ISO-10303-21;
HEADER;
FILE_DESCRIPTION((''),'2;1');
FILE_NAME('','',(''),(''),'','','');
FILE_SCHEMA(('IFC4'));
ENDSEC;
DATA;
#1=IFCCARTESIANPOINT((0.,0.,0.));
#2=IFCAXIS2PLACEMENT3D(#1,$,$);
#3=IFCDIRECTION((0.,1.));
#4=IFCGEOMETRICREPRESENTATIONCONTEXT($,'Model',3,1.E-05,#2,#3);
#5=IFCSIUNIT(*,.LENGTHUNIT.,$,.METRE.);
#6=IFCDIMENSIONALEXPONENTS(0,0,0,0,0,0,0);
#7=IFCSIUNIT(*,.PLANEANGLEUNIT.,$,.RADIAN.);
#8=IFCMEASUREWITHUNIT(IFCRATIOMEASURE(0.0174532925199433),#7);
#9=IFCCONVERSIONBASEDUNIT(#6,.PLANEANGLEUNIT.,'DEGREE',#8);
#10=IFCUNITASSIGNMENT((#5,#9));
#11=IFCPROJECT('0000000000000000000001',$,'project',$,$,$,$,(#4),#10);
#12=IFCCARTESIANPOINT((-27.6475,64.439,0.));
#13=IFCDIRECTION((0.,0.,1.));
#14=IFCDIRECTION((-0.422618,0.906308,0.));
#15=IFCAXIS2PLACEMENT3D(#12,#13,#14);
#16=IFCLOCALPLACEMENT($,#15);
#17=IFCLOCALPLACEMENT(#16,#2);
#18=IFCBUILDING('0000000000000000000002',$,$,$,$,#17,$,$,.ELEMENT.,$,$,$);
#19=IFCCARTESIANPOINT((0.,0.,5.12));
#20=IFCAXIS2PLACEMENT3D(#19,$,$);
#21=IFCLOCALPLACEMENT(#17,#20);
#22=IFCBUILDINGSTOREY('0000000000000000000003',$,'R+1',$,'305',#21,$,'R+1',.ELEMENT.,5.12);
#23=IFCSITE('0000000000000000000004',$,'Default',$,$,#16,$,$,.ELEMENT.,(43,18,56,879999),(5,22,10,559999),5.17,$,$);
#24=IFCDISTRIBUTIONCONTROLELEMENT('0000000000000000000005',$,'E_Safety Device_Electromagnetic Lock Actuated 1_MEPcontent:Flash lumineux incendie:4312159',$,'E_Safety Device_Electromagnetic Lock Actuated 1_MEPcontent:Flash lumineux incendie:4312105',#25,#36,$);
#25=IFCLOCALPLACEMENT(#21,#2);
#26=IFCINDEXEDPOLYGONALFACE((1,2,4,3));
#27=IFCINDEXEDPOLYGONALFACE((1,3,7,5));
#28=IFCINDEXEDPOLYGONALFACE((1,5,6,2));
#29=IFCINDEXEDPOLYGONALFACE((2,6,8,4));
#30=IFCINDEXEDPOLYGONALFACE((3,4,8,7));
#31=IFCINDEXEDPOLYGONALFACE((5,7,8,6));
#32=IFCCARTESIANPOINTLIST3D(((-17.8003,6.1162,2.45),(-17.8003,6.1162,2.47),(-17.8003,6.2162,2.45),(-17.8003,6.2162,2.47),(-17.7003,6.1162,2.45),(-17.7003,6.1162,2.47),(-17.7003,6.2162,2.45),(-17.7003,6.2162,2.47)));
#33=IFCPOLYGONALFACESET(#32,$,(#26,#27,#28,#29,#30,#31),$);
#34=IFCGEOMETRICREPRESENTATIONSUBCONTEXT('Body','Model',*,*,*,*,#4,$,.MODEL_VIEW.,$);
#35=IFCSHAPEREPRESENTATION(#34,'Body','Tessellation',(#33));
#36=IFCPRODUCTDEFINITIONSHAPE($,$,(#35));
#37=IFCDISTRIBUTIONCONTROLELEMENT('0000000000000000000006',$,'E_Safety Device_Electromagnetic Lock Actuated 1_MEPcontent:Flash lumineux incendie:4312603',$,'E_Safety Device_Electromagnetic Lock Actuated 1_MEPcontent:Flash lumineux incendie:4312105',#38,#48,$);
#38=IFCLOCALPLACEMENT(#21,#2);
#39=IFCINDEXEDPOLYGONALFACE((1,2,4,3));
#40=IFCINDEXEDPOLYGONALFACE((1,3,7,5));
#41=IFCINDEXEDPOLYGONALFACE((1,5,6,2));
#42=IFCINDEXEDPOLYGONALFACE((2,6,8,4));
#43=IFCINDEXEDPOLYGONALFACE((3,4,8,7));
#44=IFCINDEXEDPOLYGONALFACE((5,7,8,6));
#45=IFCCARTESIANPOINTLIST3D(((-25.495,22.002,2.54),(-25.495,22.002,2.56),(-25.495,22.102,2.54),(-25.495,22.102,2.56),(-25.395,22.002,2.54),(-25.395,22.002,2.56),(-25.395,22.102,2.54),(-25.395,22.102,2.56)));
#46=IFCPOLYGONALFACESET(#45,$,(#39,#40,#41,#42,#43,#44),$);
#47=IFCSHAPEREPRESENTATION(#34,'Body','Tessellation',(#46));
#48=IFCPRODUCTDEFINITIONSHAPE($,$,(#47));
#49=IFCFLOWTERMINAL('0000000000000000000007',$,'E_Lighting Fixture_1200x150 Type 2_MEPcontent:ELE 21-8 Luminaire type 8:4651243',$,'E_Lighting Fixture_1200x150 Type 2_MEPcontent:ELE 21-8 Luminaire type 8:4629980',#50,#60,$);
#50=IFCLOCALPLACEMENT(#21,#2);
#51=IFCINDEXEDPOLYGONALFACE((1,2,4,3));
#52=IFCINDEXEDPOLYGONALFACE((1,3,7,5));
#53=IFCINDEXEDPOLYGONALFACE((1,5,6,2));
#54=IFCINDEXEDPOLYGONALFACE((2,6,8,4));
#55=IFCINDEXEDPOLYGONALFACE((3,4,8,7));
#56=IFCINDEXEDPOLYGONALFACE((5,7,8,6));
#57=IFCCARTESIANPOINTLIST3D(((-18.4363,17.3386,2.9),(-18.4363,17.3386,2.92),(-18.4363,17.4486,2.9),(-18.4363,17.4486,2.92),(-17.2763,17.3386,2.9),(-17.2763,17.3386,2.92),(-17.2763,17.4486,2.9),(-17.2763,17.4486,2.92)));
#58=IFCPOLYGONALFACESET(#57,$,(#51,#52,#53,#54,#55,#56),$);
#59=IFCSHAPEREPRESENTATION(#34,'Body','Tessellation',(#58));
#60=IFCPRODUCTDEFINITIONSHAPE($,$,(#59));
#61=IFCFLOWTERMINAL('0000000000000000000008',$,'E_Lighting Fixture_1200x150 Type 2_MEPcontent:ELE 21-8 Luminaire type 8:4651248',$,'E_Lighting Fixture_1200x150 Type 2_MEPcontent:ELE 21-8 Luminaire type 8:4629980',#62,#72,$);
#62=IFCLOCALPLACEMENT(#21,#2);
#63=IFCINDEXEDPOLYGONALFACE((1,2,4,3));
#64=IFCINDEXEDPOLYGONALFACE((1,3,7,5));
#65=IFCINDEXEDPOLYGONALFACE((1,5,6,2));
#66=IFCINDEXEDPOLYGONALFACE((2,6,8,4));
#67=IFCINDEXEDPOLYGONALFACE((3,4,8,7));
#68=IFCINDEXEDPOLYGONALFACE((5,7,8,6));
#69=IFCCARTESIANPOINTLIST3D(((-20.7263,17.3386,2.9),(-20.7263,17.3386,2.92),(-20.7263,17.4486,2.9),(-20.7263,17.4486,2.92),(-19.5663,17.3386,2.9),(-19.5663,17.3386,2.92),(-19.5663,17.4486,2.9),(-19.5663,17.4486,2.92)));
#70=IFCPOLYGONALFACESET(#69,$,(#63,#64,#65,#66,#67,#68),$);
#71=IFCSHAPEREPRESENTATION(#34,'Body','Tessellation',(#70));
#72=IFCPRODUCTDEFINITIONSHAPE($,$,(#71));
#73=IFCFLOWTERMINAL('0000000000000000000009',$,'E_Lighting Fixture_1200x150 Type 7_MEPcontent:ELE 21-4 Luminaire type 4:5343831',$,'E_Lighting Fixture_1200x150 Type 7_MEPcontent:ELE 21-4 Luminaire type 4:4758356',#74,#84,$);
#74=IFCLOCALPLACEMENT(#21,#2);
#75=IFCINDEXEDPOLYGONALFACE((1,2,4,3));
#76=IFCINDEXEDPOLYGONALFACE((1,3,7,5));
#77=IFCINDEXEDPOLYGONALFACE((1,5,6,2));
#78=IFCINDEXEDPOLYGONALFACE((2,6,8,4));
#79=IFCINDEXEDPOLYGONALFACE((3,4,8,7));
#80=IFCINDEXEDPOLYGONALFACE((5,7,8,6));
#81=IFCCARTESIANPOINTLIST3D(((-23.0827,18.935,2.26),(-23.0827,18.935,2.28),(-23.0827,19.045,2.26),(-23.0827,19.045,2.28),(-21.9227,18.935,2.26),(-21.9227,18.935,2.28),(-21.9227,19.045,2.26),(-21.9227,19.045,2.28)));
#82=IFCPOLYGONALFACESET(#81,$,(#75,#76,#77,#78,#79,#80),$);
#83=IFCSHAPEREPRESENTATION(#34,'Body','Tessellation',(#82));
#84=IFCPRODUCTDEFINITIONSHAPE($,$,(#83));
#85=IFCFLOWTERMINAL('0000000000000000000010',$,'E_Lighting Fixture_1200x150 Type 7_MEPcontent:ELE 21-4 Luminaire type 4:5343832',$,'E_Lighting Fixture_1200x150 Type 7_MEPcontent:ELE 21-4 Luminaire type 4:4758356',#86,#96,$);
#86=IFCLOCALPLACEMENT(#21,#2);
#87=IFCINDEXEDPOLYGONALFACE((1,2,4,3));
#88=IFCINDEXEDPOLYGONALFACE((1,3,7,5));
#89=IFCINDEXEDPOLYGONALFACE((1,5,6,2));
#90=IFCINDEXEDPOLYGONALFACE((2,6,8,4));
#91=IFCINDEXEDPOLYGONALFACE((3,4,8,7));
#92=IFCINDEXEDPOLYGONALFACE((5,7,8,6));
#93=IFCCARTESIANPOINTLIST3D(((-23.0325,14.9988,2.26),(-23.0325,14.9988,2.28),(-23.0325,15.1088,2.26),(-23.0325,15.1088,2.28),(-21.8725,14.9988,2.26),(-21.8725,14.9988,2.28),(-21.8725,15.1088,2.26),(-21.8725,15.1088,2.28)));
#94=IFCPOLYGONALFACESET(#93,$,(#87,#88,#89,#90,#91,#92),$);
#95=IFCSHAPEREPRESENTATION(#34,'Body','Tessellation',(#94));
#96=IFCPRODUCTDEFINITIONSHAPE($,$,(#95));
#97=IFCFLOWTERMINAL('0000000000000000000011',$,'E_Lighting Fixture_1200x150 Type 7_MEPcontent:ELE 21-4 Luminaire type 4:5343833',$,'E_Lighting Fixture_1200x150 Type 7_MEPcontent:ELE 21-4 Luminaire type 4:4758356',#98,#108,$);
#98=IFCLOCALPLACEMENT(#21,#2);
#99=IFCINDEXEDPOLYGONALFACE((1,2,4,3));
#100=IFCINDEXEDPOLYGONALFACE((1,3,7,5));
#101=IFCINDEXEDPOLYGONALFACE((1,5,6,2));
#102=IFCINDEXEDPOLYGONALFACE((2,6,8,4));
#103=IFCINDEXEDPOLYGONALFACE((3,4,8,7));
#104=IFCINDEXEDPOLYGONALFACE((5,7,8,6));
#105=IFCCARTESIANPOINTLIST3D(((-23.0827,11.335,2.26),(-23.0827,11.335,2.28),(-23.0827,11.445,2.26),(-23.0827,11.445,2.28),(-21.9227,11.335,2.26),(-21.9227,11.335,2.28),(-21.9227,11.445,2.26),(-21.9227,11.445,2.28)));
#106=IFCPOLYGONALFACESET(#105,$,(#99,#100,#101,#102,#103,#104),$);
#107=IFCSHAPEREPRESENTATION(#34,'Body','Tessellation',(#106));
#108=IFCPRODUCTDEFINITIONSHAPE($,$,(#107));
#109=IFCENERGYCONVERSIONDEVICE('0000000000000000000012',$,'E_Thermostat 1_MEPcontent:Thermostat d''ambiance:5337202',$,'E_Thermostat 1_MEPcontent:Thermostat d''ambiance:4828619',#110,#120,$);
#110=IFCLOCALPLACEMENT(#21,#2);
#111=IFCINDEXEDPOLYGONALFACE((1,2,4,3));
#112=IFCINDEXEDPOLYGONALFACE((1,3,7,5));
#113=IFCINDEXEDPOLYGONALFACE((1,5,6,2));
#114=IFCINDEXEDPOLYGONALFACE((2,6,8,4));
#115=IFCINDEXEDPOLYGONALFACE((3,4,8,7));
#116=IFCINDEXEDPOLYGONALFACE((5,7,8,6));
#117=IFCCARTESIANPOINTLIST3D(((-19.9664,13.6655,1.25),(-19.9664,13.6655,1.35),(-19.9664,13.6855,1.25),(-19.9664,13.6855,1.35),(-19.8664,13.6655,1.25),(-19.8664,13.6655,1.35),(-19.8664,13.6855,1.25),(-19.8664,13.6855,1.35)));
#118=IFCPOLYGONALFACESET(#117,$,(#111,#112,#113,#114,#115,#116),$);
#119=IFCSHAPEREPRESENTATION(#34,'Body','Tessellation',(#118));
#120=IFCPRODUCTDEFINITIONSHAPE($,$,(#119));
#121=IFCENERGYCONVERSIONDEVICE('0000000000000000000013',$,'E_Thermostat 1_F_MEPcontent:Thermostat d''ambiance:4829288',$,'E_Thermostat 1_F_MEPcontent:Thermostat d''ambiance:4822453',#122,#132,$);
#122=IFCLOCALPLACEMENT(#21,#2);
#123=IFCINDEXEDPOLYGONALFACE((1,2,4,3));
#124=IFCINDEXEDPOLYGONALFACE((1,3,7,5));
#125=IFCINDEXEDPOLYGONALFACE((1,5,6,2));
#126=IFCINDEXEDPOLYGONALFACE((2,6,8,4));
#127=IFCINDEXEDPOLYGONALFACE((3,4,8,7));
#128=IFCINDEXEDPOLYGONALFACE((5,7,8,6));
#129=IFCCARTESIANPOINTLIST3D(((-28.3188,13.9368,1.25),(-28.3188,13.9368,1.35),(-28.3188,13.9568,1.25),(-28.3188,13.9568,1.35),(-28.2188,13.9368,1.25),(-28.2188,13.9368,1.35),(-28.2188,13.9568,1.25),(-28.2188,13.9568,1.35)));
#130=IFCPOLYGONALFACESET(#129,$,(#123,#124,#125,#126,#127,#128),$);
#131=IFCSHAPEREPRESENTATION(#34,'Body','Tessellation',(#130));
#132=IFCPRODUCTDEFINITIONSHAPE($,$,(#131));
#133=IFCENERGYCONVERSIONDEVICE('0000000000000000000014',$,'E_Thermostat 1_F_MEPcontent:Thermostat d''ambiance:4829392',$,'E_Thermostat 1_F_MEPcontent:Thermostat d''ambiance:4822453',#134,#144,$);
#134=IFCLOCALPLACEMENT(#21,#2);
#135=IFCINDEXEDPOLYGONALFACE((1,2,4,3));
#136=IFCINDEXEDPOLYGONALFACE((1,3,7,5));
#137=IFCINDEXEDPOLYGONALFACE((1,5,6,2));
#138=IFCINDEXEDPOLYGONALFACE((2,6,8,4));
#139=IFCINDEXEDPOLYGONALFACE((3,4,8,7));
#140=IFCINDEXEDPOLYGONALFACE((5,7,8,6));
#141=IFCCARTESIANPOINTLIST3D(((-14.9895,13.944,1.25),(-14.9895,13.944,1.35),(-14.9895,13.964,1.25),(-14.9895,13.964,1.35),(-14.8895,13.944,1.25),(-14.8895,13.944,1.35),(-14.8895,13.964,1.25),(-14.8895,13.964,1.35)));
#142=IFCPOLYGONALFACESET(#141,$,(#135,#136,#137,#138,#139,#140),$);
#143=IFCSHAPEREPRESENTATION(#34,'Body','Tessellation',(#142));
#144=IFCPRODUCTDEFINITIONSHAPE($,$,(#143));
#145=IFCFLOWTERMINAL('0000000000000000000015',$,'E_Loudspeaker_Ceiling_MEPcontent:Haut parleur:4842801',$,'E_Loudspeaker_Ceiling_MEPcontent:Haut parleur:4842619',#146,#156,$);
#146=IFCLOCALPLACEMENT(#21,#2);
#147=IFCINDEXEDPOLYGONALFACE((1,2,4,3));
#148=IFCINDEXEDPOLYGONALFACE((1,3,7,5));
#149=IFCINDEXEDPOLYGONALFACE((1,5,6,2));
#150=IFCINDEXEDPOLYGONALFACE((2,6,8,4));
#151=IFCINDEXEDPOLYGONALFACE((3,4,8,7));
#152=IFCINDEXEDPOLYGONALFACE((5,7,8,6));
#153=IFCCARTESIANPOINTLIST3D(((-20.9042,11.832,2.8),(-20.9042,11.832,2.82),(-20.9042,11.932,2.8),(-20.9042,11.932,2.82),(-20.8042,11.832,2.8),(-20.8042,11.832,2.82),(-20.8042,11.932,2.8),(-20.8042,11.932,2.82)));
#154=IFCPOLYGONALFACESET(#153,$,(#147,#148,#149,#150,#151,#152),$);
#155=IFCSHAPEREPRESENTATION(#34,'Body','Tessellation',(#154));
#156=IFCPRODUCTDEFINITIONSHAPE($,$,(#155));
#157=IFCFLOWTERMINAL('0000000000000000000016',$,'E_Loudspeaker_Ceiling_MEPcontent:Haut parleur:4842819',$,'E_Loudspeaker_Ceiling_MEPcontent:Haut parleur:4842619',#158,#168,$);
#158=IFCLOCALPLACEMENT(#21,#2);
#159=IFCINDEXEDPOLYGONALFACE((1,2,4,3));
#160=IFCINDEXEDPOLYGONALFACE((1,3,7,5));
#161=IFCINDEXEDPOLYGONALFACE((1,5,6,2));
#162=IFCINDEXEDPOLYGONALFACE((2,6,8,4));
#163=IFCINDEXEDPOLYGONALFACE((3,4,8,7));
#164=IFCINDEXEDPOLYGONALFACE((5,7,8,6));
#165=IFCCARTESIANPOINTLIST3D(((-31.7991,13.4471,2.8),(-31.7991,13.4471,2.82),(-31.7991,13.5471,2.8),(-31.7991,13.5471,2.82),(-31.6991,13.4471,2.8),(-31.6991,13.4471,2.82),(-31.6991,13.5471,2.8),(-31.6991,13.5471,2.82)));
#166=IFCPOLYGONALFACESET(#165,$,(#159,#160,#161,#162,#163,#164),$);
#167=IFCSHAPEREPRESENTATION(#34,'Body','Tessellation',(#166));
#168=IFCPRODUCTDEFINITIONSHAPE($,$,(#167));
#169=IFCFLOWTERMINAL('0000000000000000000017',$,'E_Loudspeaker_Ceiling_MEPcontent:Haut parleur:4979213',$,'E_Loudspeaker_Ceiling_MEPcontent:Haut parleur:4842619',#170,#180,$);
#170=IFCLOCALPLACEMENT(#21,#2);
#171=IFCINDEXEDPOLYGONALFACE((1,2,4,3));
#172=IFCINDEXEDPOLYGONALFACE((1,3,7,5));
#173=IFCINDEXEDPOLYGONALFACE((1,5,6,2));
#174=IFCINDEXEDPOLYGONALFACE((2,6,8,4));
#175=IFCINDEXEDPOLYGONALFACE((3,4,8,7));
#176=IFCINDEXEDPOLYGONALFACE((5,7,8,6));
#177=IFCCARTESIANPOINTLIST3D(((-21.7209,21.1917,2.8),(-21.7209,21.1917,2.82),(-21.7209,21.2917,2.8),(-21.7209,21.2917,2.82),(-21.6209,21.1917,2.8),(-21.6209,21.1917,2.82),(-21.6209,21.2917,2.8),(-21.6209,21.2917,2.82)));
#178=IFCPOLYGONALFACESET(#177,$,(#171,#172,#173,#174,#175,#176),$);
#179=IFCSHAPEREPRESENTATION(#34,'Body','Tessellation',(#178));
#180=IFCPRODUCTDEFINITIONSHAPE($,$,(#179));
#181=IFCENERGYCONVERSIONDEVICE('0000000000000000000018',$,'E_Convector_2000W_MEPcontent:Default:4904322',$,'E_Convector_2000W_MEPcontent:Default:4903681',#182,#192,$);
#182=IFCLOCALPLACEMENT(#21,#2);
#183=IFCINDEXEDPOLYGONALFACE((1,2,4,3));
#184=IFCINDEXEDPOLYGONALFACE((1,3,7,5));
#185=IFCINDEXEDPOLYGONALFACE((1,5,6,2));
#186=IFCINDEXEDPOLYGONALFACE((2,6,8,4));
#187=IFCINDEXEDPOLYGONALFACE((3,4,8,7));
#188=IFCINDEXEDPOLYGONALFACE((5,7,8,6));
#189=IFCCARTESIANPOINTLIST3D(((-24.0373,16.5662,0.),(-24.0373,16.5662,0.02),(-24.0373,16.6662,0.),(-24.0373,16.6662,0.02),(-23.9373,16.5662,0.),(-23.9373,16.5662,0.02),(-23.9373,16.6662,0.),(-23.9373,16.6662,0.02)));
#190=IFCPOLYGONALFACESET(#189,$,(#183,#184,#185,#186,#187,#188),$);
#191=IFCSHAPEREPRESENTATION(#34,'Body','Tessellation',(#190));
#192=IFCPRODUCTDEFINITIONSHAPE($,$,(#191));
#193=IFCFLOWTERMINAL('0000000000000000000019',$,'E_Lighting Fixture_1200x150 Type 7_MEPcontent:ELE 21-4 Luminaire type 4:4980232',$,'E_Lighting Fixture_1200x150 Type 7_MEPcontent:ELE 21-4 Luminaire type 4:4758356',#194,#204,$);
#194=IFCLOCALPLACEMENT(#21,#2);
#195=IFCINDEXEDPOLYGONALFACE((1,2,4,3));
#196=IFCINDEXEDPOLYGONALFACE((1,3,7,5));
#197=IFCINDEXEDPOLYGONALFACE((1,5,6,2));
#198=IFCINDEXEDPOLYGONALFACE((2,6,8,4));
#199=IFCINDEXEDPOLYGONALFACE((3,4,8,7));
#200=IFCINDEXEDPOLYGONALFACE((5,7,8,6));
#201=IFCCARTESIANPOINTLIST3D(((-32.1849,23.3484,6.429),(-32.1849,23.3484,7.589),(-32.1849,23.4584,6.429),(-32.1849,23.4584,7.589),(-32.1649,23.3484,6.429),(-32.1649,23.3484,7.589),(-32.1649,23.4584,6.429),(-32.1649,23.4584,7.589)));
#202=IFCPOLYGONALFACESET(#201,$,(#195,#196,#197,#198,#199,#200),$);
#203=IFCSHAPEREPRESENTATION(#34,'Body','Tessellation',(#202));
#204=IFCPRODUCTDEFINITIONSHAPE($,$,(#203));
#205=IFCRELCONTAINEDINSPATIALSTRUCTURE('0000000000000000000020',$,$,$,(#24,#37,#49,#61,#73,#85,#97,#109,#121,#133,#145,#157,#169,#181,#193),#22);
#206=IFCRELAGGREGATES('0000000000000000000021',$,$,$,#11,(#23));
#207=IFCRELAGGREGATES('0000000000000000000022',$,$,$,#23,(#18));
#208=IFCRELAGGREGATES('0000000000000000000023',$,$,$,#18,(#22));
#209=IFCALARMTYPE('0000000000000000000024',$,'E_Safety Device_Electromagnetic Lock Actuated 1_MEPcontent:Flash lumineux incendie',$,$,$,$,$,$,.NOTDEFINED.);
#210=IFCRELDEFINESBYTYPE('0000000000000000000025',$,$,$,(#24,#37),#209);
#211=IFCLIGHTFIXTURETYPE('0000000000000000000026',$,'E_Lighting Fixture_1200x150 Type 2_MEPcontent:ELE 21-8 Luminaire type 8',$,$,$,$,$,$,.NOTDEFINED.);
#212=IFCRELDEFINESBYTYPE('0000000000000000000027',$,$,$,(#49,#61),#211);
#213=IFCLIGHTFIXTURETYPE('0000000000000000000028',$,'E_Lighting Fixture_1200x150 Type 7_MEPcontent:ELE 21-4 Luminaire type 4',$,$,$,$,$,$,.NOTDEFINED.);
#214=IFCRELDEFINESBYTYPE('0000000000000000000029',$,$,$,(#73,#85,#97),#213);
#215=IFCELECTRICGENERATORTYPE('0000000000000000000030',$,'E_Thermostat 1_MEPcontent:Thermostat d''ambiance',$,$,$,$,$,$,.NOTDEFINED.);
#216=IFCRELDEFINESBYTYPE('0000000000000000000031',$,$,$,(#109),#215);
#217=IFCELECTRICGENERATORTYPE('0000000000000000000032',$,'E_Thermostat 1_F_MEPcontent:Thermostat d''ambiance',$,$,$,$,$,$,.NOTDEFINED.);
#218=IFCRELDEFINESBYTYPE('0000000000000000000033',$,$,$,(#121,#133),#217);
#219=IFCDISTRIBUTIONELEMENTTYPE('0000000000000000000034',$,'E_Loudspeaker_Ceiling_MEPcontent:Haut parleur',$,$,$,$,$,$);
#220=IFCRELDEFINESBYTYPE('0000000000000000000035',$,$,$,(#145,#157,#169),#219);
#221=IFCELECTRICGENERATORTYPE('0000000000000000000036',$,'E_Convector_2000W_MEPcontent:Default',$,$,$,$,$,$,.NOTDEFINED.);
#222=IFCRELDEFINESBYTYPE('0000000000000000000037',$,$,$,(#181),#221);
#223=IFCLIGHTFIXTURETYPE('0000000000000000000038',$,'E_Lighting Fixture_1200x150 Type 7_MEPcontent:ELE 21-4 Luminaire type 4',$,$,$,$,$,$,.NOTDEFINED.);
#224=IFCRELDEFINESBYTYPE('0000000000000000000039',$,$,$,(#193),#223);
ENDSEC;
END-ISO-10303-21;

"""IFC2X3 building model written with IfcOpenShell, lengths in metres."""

from ifc_helpers import new_model, entity, si_unit, converted_unit, direction, frame, frame_2d, origin, origin_2d_with_axis, place, context, subcontext, project, spatial, rectangle, extrude, source, transform, mapped, type_object, type_shapes, element, save


model = new_model("IFC2X3")

# Units and contexts
model_context = context("Model", 3, precision=1e-05, world=origin(), true_north=direction((0.0, 1.0)))
body_context = subcontext(model_context, "Body", "Model", "MODEL_VIEW")
ifc_project = project(units=[si_unit("LENGTHUNIT", "METRE"), converted_unit("PLANEANGLEUNIT", "DEGREE", entity("IfcRatioMeasure", 0.0174532925199433), si_unit("PLANEANGLEUNIT", "RADIAN"), dimensions=[0, 0, 0, 0, 0, 0, 0])], contexts=[model_context])

# Site, building, storey
site_placement = place(None, frame((-27.6475, 64.439, 0.0), z_axis=(0.0, 0.0, 1.0), x_axis=(-0.422618, 0.906308, 0.0)))
site = spatial("IfcSite", under=ifc_project, at=site_placement, Name="Default", CompositionType="ELEMENT", RefLatitude=(43, 18, 56, 879999), RefLongitude=(5, 22, 10, 559999), RefElevation=5.17)
building_placement = place(site_placement, origin())
building = spatial("IfcBuilding", under=site, at=building_placement, CompositionType="ELEMENT")
storey_placement = place(building_placement, frame((0.0, 0.0, 5.12)))
storey = spatial("IfcBuildingStorey", under=building, at=storey_placement, Name="R+1", ObjectType="305", LongName="R+1", CompositionType="ELEMENT", Elevation=5.12)

# Distribution control elements
alarm_type = type_object("IfcAlarmType", Name="E_Safety Device_Electromagnetic Lock Actuated 1_MEPcontent:Flash lumineux incendie", PredefinedType="NOTDEFINED")
shared_shape_1 = source(origin(), body_context, "Body", "SweptSolid", [
    extrude(rectangle(XDim=0.1, YDim=0.1, at=origin_2d_with_axis()), frame((0.0, 0.0, 0.0), z_axis=(0.0, 0.0, 1.0), x_axis=(0.0, -1.0, 0.0)), (0.0, 0.0, 1.0), 0.02),
])
type_shapes(alarm_type, [shared_shape_1])
for number, where, z_axis, x_axis, name in (
    (1, (-17.7503, 6.1662, 2.45), (0.0, 0.0, 1.0), (0.0, -1.0, 0.0), "E_Safety Device_Electromagnetic Lock Actuated 1_MEPcontent:Flash lumineux incendie:4312159"),
    (2, (-25.445, 22.052, 2.54), (0.0, 0.0, 1.0), (0.0, -1.0, 0.0), "E_Safety Device_Electromagnetic Lock Actuated 1_MEPcontent:Flash lumineux incendie:4312603"),
):
    element("IfcDistributionControlElement", number, at=place(storey_placement, frame(where, z_axis=z_axis, x_axis=x_axis)), inside=storey, type_object=alarm_type, Name=name, ObjectType="E_Safety Device_Electromagnetic Lock Actuated 1_MEPcontent:Flash lumineux incendie:4312105", context=body_context, shape_type="MappedRepresentation", body=[
        mapped(shared_shape_1, transform((0.0, 0.0, 0.0), scale=1.0)),
    ])

# Flow terminals
light_fixture_type_1 = type_object("IfcLightFixtureType", Name="E_Lighting Fixture_1200x150 Type 2_MEPcontent:ELE 21-8 Luminaire type 8", PredefinedType="NOTDEFINED")
shared_shape_2 = source(origin(), body_context, "Body", "SweptSolid", [
    extrude(rectangle(XDim=0.11, YDim=1.16, at=origin_2d_with_axis()), frame((0.0, 0.0, 0.0), z_axis=(0.0, 0.0, 1.0), x_axis=(0.0, -1.0, 0.0)), (0.0, 0.0, 1.0), 0.02),
])
type_shapes(light_fixture_type_1, [shared_shape_2])
for number, where, z_axis, x_axis, name in (
    (3, (-17.8563, 17.3936, 2.9), (0.0, 0.0, 1.0), (-1.0, 0.0, 0.0), "E_Lighting Fixture_1200x150 Type 2_MEPcontent:ELE 21-8 Luminaire type 8:4651243"),
    (4, (-20.1463, 17.3936, 2.9), (0.0, 0.0, 1.0), (-1.0, 0.0, 0.0), "E_Lighting Fixture_1200x150 Type 2_MEPcontent:ELE 21-8 Luminaire type 8:4651248"),
):
    element("IfcFlowTerminal", number, at=place(storey_placement, frame(where, z_axis=z_axis, x_axis=x_axis)), inside=storey, type_object=light_fixture_type_1, Name=name, ObjectType="E_Lighting Fixture_1200x150 Type 2_MEPcontent:ELE 21-8 Luminaire type 8:4629980", context=body_context, shape_type="MappedRepresentation", body=[
        mapped(shared_shape_2, transform((0.0, 0.0, 0.0), scale=1.0)),
    ])
light_fixture_type_2 = type_object("IfcLightFixtureType", Name="E_Lighting Fixture_1200x150 Type 7_MEPcontent:ELE 21-4 Luminaire type 4", PredefinedType="NOTDEFINED")
shared_shape_3 = source(origin(), body_context, "Body", "SweptSolid", [
    extrude(rectangle(XDim=0.11, YDim=1.16, at=origin_2d_with_axis()), frame((0.0, 0.0, 0.0), z_axis=(0.0, 0.0, 1.0), x_axis=(0.0, -1.0, 0.0)), (0.0, 0.0, 1.0), 0.02),
])
type_shapes(light_fixture_type_2, [shared_shape_3])
for number, where, name in (
    (5, (-22.5027, 18.99, 2.26), "E_Lighting Fixture_1200x150 Type 7_MEPcontent:ELE 21-4 Luminaire type 4:5343831"),
    (6, (-22.4525, 15.0538, 2.26), "E_Lighting Fixture_1200x150 Type 7_MEPcontent:ELE 21-4 Luminaire type 4:5343832"),
    (7, (-22.5027, 11.39, 2.26), "E_Lighting Fixture_1200x150 Type 7_MEPcontent:ELE 21-4 Luminaire type 4:5343833"),
):
    element("IfcFlowTerminal", number, at=place(storey_placement, frame(where)), inside=storey, type_object=light_fixture_type_2, Name=name, ObjectType="E_Lighting Fixture_1200x150 Type 7_MEPcontent:ELE 21-4 Luminaire type 4:4758356", context=body_context, shape_type="MappedRepresentation", body=[
        mapped(shared_shape_3, transform((0.0, 0.0, 0.0), scale=1.0)),
    ])

# Energy conversion devices
electric_generator_type_1 = type_object("IfcElectricGeneratorType", Name="E_Thermostat 1_MEPcontent:Thermostat d'ambiance", PredefinedType="NOTDEFINED")
shared_shape_4 = source(origin(), body_context, "Body", "SweptSolid", [
    extrude(rectangle(XDim=0.02, YDim=0.1, at=frame_2d((0.0, 0.0), x_axis=(1.0, 0.0))), frame((0.0, 0.01, -0.05), z_axis=(0.0, 0.0, 1.0), x_axis=(0.0, -1.0, 0.0)), (0.0, 0.0, 1.0), 0.1),
])
type_shapes(electric_generator_type_1, [shared_shape_4])
energy_conversion_device_1_placement = place(storey_placement, frame((-19.9164, 13.6855, 1.3), z_axis=(0.0, 0.0, 1.0), x_axis=(-1.0, 0.0, 0.0)))
element("IfcEnergyConversionDevice", 8, at=energy_conversion_device_1_placement, inside=storey, type_object=electric_generator_type_1, Name="E_Thermostat 1_MEPcontent:Thermostat d'ambiance:5337202", ObjectType="E_Thermostat 1_MEPcontent:Thermostat d'ambiance:4828619", context=body_context, shape_type="MappedRepresentation", body=[
    mapped(shared_shape_4, transform((0.0, 0.0, 0.0), scale=1.0)),
])
electric_generator_type_2 = type_object("IfcElectricGeneratorType", Name="E_Thermostat 1_F_MEPcontent:Thermostat d'ambiance", PredefinedType="NOTDEFINED")
shared_shape_5 = source(origin(), body_context, "Body", "SweptSolid", [
    extrude(rectangle(XDim=0.1, YDim=0.1, at=origin_2d_with_axis()), frame((0.0, 0.0, 0.0), z_axis=(0.0, 0.0, 1.0), x_axis=(0.0, 1.0, 0.0)), (0.0, 0.0, 1.0), 0.02),
])
type_shapes(electric_generator_type_2, [shared_shape_5])
for number, where, z_axis, x_axis, name in (
    (9, (-28.2688, 13.9368, 1.3), (0.0, 1.0, 0.0), (-1.0, 0.0, 0.0), "E_Thermostat 1_F_MEPcontent:Thermostat d'ambiance:4829288"),
    (10, (-14.9395, 13.944, 1.3), (0.0, 1.0, 0.0), (-1.0, 0.0, 0.0), "E_Thermostat 1_F_MEPcontent:Thermostat d'ambiance:4829392"),
):
    element("IfcEnergyConversionDevice", number, at=place(storey_placement, frame(where, z_axis=z_axis, x_axis=x_axis)), inside=storey, type_object=electric_generator_type_2, Name=name, ObjectType="E_Thermostat 1_F_MEPcontent:Thermostat d'ambiance:4822453", context=body_context, shape_type="MappedRepresentation", body=[
        mapped(shared_shape_5, transform((0.0, 0.0, 0.0), scale=1.0)),
    ])

# Flow terminals
distribution_element_type = type_object("IfcDistributionElementType", Name="E_Loudspeaker_Ceiling_MEPcontent:Haut parleur")
shared_shape_6 = source(origin(), body_context, "Body", "SweptSolid", [
    extrude(rectangle(XDim=0.1, YDim=0.1, at=origin_2d_with_axis()), frame((0.0, 0.0, 0.0), z_axis=(0.0, 0.0, 1.0), x_axis=(0.0, -1.0, 0.0)), (0.0, 0.0, 1.0), 0.02),
])
type_shapes(distribution_element_type, [shared_shape_6])
for number, where, z_axis, x_axis, name in (
    (11, (-20.8542, 11.882, 2.8), (0.0, 0.0, 1.0), (0.0, -1.0, 0.0), "E_Loudspeaker_Ceiling_MEPcontent:Haut parleur:4842801"),
    (12, (-31.7491, 13.4971, 2.8), (0.0, 0.0, 1.0), (-1.0, 0.0, 0.0), "E_Loudspeaker_Ceiling_MEPcontent:Haut parleur:4842819"),
    (13, (-21.6709, 21.2417, 2.8), (0.0, 0.0, 1.0), (0.0, 1.0, 0.0), "E_Loudspeaker_Ceiling_MEPcontent:Haut parleur:4979213"),
):
    element("IfcFlowTerminal", number, at=place(storey_placement, frame(where, z_axis=z_axis, x_axis=x_axis)), inside=storey, type_object=distribution_element_type, Name=name, ObjectType="E_Loudspeaker_Ceiling_MEPcontent:Haut parleur:4842619", context=body_context, shape_type="MappedRepresentation", body=[
        mapped(shared_shape_6, transform((0.0, 0.0, 0.0), scale=1.0)),
    ])

# Energy conversion device
electric_generator_type_3 = type_object("IfcElectricGeneratorType", Name="E_Convector_2000W_MEPcontent:Default", PredefinedType="NOTDEFINED")
shared_shape_7 = source(origin(), body_context, "Body", "SweptSolid", [
    extrude(rectangle(XDim=0.1, YDim=0.1, at=origin_2d_with_axis()), frame((0.0, 0.0, 0.0), z_axis=(0.0, 0.0, 1.0), x_axis=(0.0, -1.0, 0.0)), (0.0, 0.0, 1.0), 0.02),
])
type_shapes(electric_generator_type_3, [shared_shape_7])
energy_conversion_device_2_placement = place(storey_placement, frame((-23.9873, 16.6162, 0.0), z_axis=(0.0, 0.0, 1.0), x_axis=(0.0, 1.0, 0.0)))
element("IfcEnergyConversionDevice", 14, at=energy_conversion_device_2_placement, inside=storey, type_object=electric_generator_type_3, Name="E_Convector_2000W_MEPcontent:Default:4904322", ObjectType="E_Convector_2000W_MEPcontent:Default:4903681", context=body_context, shape_type="MappedRepresentation", body=[
    mapped(shared_shape_7, transform((0.0, 0.0, 0.0), scale=1.0)),
])

# Flow terminal
light_fixture_type_3 = type_object("IfcLightFixtureType", Name="E_Lighting Fixture_1200x150 Type 7_MEPcontent:ELE 21-4 Luminaire type 4", PredefinedType="NOTDEFINED")
shared_shape_8 = source(origin(), body_context, "Body", "SweptSolid", [
    extrude(rectangle(XDim=0.02, YDim=0.11, at=frame_2d((0.0, 0.0), x_axis=(1.0, 0.0))), frame((0.01, 0.0, -0.58), z_axis=(0.0, 0.0, 1.0), x_axis=(-1.0, 0.0, 0.0)), (0.0, 0.0, 1.0), 1.16),
])
type_shapes(light_fixture_type_3, [shared_shape_8])
for number, where, name in (
    (15, (-32.1849, 23.4034, 7.009), "E_Lighting Fixture_1200x150 Type 7_MEPcontent:ELE 21-4 Luminaire type 4:4980232"),
):
    element("IfcFlowTerminal", number, at=place(storey_placement, frame(where)), inside=storey, type_object=light_fixture_type_3, Name=name, ObjectType="E_Lighting Fixture_1200x150 Type 7_MEPcontent:ELE 21-4 Luminaire type 4:4758356", context=body_context, shape_type="MappedRepresentation", body=[
        mapped(shared_shape_8, transform((0.0, 0.0, 0.0), scale=1.0)),
    ])

save(model, "model.ifc")
